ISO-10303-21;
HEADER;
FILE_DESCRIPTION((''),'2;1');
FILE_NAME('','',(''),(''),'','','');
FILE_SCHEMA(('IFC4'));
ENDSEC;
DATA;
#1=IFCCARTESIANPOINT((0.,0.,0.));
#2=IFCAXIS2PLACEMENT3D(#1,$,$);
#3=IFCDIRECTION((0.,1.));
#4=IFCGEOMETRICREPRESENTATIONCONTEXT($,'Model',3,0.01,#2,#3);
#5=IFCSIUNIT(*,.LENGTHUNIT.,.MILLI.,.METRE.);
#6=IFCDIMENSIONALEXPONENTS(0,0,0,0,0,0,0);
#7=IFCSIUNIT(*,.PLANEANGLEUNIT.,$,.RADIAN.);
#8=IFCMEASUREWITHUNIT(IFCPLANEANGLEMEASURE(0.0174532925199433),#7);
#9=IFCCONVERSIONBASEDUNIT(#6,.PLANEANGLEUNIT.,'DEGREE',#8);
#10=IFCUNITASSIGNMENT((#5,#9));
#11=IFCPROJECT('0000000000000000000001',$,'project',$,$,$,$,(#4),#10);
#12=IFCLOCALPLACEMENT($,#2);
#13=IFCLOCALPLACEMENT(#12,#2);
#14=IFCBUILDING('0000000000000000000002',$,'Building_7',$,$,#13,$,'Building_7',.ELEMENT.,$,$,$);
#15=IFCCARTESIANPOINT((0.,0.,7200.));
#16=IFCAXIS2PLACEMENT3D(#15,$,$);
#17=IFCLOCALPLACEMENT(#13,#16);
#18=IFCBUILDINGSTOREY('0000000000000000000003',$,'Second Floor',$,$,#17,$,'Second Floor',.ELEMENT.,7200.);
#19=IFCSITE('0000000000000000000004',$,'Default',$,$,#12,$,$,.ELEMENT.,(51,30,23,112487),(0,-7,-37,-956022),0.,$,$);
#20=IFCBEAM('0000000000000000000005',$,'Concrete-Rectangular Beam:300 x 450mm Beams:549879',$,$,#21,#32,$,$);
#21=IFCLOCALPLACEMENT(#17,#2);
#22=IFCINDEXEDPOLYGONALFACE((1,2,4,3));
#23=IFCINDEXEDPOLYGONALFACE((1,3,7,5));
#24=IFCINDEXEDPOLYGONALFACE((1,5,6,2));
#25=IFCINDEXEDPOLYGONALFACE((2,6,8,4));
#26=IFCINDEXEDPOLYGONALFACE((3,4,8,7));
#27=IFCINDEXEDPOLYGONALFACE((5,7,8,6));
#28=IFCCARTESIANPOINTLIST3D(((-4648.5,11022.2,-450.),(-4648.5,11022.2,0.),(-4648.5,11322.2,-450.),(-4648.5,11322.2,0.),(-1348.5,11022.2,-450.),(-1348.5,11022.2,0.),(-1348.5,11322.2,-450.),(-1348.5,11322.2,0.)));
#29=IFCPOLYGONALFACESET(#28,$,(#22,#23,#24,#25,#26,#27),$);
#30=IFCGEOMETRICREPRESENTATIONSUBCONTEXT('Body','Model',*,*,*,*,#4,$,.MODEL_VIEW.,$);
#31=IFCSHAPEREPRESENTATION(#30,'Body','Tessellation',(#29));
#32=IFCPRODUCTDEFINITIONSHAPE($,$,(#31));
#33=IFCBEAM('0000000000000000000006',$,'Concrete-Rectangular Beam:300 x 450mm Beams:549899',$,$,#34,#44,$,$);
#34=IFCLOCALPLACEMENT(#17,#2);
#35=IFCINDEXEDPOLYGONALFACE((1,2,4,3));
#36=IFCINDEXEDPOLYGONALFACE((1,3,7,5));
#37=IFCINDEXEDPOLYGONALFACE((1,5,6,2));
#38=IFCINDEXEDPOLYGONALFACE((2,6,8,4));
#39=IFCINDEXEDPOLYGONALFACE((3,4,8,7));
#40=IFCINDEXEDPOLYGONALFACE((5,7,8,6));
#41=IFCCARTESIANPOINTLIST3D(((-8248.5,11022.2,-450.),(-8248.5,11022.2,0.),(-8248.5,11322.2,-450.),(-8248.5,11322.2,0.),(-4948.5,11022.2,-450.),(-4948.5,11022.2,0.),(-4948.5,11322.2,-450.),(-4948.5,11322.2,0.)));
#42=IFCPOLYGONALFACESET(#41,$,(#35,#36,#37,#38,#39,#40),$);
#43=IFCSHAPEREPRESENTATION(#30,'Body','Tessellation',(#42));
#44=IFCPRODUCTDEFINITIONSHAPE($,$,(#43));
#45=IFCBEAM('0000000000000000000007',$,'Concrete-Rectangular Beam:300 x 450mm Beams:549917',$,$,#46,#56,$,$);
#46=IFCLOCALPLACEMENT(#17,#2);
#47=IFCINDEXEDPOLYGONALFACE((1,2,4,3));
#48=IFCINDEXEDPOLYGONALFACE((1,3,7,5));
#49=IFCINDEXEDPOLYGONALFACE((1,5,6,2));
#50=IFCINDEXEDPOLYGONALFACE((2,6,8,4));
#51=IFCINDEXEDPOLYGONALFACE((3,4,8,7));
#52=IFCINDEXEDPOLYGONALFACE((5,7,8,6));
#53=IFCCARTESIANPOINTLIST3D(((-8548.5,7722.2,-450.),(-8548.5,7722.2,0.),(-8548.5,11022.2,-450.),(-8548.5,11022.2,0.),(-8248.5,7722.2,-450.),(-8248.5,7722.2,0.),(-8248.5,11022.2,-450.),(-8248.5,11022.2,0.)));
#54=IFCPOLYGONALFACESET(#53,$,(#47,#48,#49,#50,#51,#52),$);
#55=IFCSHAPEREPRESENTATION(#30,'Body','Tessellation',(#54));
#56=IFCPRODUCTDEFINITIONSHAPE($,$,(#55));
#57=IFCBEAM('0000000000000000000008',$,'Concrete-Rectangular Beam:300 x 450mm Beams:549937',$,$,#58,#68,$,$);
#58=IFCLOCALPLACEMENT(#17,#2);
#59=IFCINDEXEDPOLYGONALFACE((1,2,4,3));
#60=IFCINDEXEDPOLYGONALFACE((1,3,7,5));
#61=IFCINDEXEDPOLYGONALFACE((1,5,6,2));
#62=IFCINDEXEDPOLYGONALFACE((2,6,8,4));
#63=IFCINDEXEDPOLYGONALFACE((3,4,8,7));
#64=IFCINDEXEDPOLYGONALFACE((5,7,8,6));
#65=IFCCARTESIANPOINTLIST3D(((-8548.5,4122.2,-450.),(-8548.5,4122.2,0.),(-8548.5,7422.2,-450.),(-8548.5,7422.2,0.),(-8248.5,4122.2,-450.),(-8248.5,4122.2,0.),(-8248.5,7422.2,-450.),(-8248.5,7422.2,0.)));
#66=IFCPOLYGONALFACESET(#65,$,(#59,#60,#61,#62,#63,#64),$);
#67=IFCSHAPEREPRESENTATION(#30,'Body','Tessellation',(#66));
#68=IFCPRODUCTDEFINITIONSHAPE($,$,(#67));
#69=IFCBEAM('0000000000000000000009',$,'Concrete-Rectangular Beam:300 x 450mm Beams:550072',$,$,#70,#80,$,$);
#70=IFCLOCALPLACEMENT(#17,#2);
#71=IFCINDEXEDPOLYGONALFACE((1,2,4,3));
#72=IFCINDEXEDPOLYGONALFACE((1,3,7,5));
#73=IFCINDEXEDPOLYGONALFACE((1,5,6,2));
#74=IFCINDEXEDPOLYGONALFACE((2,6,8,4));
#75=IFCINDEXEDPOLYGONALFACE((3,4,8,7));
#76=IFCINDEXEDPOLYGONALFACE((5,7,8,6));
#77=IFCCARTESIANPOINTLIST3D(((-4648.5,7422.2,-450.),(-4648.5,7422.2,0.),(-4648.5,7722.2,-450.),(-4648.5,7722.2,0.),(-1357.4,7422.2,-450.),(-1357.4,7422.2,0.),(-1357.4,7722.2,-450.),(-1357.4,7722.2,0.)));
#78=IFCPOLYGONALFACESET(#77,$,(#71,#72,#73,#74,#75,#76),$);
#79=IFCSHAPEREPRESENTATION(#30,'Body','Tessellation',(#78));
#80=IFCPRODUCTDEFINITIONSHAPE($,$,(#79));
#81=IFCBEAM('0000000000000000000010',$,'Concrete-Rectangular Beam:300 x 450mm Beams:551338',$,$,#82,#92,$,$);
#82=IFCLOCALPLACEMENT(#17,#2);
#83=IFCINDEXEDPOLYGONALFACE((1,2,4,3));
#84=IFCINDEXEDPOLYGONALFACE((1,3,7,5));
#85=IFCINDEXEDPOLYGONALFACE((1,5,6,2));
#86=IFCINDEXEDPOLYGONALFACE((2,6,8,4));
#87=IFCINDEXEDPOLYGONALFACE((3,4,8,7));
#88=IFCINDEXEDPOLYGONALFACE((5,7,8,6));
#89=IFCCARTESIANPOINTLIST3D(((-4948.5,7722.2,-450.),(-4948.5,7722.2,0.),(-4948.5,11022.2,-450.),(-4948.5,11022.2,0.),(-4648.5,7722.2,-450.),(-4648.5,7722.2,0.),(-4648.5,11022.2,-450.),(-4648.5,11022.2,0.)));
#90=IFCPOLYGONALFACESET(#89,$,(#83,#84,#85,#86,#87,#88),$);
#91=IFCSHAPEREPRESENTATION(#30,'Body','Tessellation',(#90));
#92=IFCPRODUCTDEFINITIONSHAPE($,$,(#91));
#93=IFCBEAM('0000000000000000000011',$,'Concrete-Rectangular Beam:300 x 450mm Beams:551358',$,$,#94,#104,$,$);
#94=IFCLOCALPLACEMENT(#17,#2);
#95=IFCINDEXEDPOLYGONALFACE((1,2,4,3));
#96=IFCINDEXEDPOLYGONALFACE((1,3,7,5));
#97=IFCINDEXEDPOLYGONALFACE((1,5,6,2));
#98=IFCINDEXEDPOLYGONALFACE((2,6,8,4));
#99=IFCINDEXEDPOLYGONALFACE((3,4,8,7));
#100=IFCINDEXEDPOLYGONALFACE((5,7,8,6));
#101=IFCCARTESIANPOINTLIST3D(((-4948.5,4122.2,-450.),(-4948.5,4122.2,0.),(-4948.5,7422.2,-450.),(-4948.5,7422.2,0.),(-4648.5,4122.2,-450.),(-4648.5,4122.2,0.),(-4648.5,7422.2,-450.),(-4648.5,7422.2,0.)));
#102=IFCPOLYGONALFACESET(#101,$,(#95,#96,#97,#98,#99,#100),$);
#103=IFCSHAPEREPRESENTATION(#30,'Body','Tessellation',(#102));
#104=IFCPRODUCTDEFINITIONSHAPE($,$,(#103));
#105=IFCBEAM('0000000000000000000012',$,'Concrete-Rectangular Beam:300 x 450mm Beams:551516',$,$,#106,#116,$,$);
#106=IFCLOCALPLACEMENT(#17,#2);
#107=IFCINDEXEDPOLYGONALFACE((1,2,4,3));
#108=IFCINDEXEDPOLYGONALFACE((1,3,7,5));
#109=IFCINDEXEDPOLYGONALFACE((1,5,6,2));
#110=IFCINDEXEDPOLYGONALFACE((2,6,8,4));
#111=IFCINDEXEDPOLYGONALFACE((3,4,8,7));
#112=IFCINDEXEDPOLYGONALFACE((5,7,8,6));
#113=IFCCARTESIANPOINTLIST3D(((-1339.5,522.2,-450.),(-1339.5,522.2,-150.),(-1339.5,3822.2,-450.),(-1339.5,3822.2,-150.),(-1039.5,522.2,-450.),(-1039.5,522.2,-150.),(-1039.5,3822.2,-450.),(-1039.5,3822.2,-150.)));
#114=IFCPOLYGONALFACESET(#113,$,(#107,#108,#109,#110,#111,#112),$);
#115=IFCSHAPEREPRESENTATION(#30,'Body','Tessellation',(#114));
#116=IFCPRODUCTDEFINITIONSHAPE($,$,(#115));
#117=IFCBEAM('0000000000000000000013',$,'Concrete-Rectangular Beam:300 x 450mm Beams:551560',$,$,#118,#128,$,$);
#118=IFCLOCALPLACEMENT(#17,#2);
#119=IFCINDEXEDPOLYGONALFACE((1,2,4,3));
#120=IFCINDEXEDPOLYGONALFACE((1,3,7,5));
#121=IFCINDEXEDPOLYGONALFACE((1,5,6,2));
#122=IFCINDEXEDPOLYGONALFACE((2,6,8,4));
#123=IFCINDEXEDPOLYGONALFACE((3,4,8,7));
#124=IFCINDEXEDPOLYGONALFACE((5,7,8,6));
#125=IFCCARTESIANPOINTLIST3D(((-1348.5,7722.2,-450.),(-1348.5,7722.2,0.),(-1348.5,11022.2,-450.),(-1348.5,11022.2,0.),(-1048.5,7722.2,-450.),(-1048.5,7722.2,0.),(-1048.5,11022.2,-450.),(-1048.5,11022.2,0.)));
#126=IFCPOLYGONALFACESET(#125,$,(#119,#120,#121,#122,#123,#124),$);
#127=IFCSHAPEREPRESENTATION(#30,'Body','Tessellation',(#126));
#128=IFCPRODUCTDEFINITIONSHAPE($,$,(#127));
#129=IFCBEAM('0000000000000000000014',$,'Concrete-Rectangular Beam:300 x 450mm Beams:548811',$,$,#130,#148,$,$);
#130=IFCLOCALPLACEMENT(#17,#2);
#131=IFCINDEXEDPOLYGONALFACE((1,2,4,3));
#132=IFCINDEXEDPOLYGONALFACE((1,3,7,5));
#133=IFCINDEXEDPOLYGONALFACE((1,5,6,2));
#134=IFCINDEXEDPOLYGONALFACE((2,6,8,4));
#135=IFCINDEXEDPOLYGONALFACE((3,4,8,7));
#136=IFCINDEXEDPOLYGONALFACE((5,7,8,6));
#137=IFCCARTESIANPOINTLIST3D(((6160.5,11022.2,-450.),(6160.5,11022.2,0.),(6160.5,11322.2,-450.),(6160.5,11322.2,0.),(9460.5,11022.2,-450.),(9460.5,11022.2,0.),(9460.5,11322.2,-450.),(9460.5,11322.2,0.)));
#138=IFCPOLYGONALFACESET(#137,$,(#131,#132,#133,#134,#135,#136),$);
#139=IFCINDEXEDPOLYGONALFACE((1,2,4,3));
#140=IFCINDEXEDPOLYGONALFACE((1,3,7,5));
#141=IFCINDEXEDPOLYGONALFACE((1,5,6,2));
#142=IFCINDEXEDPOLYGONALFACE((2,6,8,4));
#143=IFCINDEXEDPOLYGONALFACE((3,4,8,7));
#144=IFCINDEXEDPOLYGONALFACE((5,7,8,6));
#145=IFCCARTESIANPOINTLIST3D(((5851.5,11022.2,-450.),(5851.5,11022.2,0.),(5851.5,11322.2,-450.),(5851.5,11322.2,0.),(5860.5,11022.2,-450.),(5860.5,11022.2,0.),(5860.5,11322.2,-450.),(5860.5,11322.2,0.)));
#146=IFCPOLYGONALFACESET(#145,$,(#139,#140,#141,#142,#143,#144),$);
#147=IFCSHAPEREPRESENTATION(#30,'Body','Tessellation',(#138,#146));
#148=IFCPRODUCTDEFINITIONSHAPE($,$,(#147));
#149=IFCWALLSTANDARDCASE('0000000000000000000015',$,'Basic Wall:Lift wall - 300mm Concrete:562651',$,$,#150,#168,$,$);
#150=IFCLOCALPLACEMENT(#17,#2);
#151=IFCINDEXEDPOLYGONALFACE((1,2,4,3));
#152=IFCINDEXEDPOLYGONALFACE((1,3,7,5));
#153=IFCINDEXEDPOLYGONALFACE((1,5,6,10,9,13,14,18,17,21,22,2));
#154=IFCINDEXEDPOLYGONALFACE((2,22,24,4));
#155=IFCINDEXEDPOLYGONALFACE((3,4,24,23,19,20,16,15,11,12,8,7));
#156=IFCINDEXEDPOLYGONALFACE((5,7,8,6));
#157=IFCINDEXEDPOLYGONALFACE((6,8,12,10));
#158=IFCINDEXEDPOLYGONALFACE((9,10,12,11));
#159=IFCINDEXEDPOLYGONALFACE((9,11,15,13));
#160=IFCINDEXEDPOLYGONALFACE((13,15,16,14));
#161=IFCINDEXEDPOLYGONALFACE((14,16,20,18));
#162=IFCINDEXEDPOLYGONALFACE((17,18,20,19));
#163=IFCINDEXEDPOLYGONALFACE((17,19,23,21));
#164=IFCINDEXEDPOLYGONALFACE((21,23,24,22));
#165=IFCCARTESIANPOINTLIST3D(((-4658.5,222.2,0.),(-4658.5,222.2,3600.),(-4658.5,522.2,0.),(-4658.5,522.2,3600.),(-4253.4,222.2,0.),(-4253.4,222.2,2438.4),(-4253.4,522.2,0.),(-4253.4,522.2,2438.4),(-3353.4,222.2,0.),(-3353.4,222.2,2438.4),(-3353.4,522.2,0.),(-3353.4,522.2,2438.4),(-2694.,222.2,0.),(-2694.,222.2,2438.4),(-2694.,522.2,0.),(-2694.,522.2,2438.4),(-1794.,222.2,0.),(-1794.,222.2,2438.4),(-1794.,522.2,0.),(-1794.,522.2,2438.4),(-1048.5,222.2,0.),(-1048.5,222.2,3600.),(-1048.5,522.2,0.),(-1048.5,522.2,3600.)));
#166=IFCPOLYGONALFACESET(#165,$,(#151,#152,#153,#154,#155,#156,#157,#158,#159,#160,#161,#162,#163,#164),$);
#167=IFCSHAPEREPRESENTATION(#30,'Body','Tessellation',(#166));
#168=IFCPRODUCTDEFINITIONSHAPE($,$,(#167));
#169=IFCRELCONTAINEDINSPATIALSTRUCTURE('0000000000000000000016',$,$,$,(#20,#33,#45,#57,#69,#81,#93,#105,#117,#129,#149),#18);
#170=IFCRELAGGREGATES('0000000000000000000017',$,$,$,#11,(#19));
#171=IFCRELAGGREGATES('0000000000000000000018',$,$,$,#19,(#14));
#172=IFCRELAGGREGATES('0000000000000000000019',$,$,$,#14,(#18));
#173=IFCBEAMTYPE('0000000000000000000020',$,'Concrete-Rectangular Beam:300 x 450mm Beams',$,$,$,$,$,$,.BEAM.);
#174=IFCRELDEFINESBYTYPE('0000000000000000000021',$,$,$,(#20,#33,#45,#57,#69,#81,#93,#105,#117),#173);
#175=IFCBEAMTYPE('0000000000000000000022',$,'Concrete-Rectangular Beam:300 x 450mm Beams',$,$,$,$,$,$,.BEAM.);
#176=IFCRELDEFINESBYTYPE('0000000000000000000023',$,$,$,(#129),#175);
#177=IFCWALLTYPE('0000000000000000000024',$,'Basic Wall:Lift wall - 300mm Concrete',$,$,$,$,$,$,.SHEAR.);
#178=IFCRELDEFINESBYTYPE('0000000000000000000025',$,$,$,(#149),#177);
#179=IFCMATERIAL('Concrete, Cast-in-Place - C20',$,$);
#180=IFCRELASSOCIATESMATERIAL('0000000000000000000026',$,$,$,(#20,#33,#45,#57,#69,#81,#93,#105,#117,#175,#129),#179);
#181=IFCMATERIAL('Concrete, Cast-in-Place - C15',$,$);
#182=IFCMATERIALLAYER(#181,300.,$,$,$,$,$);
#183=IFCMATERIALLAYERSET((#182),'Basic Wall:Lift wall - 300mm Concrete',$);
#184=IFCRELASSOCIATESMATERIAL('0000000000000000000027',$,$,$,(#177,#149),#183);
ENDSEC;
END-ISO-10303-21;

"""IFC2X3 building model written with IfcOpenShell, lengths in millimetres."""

from ifc_helpers import new_model, entity, si_unit, converted_unit, direction, frame, frame_2d, origin, origin_2d_with_axis, place, context, subcontext, project, spatial, rectangle, extrude, source, transform, mapped, material, layer, layer_set, layer_usage, type_object, type_shapes, element, save


model = new_model("IFC2X3")

# Units and contexts
model_context = context("Model", 3, precision=0.01, world=origin(), true_north=direction((0.0, 1.0)))
body_context = subcontext(model_context, "Body", "Model", "MODEL_VIEW")
ifc_project = project(units=[si_unit("LENGTHUNIT", "METRE", prefix="MILLI"), converted_unit("PLANEANGLEUNIT", "DEGREE", entity("IfcPlaneAngleMeasure", 0.0174532925199433), si_unit("PLANEANGLEUNIT", "RADIAN"), dimensions=[0, 0, 0, 0, 0, 0, 0])], contexts=[model_context])

# Site, building, storey
site_placement = place(None, origin())
site = spatial("IfcSite", under=ifc_project, at=site_placement, Name="Default", CompositionType="ELEMENT", RefLatitude=(51, 30, 23, 112487), RefLongitude=(0, -7, -37, -956022), RefElevation=0.0)
building_placement = place(site_placement, origin())
building = spatial("IfcBuilding", under=site, at=building_placement, Name="Building_7", LongName="Building_7", CompositionType="ELEMENT")
storey_placement = place(building_placement, frame((0.0, 0.0, 7200.0)))
storey = spatial("IfcBuildingStorey", under=building, at=storey_placement, Name="Second Floor", LongName="Second Floor", CompositionType="ELEMENT", Elevation=7200.0)

# Beams
ifc_material_1 = material(Name="Concrete, Cast-in-Place - C20")
beam_type_1 = type_object("IfcBeamType", Name="Concrete-Rectangular Beam:300 x 450mm Beams", PredefinedType="BEAM")
beam_1_placement = place(storey_placement, frame((-1198.5, 11172.2, 0.0), z_axis=(0.0, 0.0, 1.0), x_axis=(-1.0, 0.0, 0.0)))
element("IfcBeam", 1, at=beam_1_placement, inside=storey, type_object=beam_type_1, material=ifc_material_1, Name="Concrete-Rectangular Beam:300 x 450mm Beams:549879", context=body_context, shape_type="SweptSolid", body=[
    extrude(rectangle(XDim=450.0, YDim=300.0, at=frame_2d((0.0, 0.0), x_axis=(1.0, 0.0))), frame((150.0, 0.0, -225.0), z_axis=(1.0, 0.0, 0.0), x_axis=(0.0, 0.0, -1.0)), (0.0, 0.0, 1.0), 3300.0),
])
beam_2_placement = place(storey_placement, frame((-4798.5, 11172.2, 0.0), z_axis=(0.0, 0.0, 1.0), x_axis=(-1.0, 0.0, 0.0)))
element("IfcBeam", 2, at=beam_2_placement, inside=storey, type_object=beam_type_1, material=ifc_material_1, Name="Concrete-Rectangular Beam:300 x 450mm Beams:549899", context=body_context, shape_type="SweptSolid", body=[
    extrude(rectangle(XDim=450.0, YDim=300.0, at=frame_2d((0.0, 0.0), x_axis=(1.0, 0.0))), frame((150.0, 0.0, -225.0), z_axis=(1.0, 0.0, 0.0), x_axis=(0.0, 0.0, -1.0)), (0.0, 0.0, 1.0), 3300.0),
])
beam_3_placement = place(storey_placement, frame((-8398.5, 11172.2, 0.0), z_axis=(0.0, 0.0, 1.0), x_axis=(0.0, -1.0, 0.0)))
element("IfcBeam", 3, at=beam_3_placement, inside=storey, type_object=beam_type_1, material=ifc_material_1, Name="Concrete-Rectangular Beam:300 x 450mm Beams:549917", context=body_context, shape_type="SweptSolid", body=[
    extrude(rectangle(XDim=450.0, YDim=300.0, at=frame_2d((0.0, 0.0), x_axis=(1.0, 0.0))), frame((150.0, 0.0, -225.0), z_axis=(1.0, 0.0, 0.0), x_axis=(0.0, 0.0, -1.0)), (0.0, 0.0, 1.0), 3300.0),
])
beam_4_placement = place(storey_placement, frame((-8398.5, 7572.2, 0.0), z_axis=(0.0, 0.0, 1.0), x_axis=(0.0, -1.0, 0.0)))
element("IfcBeam", 4, at=beam_4_placement, inside=storey, type_object=beam_type_1, material=ifc_material_1, Name="Concrete-Rectangular Beam:300 x 450mm Beams:549937", context=body_context, shape_type="SweptSolid", body=[
    extrude(rectangle(XDim=450.0, YDim=300.0, at=frame_2d((0.0, 0.0), x_axis=(1.0, 0.0))), frame((150.0, 0.0, -225.0), z_axis=(1.0, 0.0, 0.0), x_axis=(0.0, 0.0, -1.0)), (0.0, 0.0, 1.0), 3300.0),
])
beam_5_placement = place(storey_placement, frame((-1207.4, 7572.2, 0.0), z_axis=(0.0, 0.0, 1.0), x_axis=(-1.0, 0.0, 0.0)))
element("IfcBeam", 5, at=beam_5_placement, inside=storey, type_object=beam_type_1, material=ifc_material_1, Name="Concrete-Rectangular Beam:300 x 450mm Beams:550072", context=body_context, shape_type="SweptSolid", body=[
    extrude(rectangle(XDim=450.0, YDim=300.0, at=origin_2d_with_axis()), frame((150.0, 0.0, -225.0), z_axis=(1.0, 0.0, 0.0), x_axis=(0.0, 0.0, -1.0)), (0.0, 0.0, 1.0), 3291.1),
])
for number, where, z_axis, x_axis, name in (
    (6, (-4798.5, 11172.2, 0.0), (0.0, 0.0, 1.0), (0.0, -1.0, 0.0), "Concrete-Rectangular Beam:300 x 450mm Beams:551338"),
    (7, (-4798.5, 7572.2, 0.0), (0.0, 0.0, 1.0), (0.0, -1.0, 0.0), "Concrete-Rectangular Beam:300 x 450mm Beams:551358"),
):
    element("IfcBeam", number, at=place(storey_placement, frame(where, z_axis=z_axis, x_axis=x_axis)), inside=storey, type_object=beam_type_1, material=ifc_material_1, Name=name, context=body_context, shape_type="SweptSolid", body=[
        extrude(rectangle(XDim=450.0, YDim=300.0, at=origin_2d_with_axis()), frame((150.0, 0.0, -225.0), z_axis=(1.0, 0.0, 0.0), x_axis=(0.0, 0.0, -1.0)), (0.0, 0.0, 1.0), 3300.0),
    ])
beam_6_placement = place(storey_placement, frame((-1189.5, 372.2, 0.0), z_axis=(0.0, 0.0, 1.0), x_axis=(0.0, 1.0, 0.0)))
element("IfcBeam", 8, at=beam_6_placement, inside=storey, type_object=beam_type_1, material=ifc_material_1, Name="Concrete-Rectangular Beam:300 x 450mm Beams:551516", context=body_context, shape_type="SweptSolid", body=[
    extrude(rectangle(XDim=300.0, YDim=300.0, at=frame_2d((0.0, 0.0), x_axis=(1.0, 0.0))), frame((150.0, 0.0, -300.0), z_axis=(1.0, 0.0, 0.0), x_axis=(0.0, 0.0, -1.0)), (0.0, 0.0, 1.0), 3300.0),
])
beam_7_placement = place(storey_placement, frame((-1198.5, 11172.2, 0.0), z_axis=(0.0, 0.0, 1.0), x_axis=(0.0, -1.0, 0.0)))
element("IfcBeam", 9, at=beam_7_placement, inside=storey, type_object=beam_type_1, material=ifc_material_1, Name="Concrete-Rectangular Beam:300 x 450mm Beams:551560", context=body_context, shape_type="SweptSolid", body=[
    extrude(rectangle(XDim=450.0, YDim=300.0, at=origin_2d_with_axis()), frame((150.0, 0.0, -225.0), z_axis=(1.0, 0.0, 0.0), x_axis=(0.0, 0.0, -1.0)), (0.0, 0.0, 1.0), 3300.0),
])

# Beam
beam_type_2 = type_object("IfcBeamType", Name="Concrete-Rectangular Beam:300 x 450mm Beams", PredefinedType="BEAM", material=ifc_material_1)
shared_shape_1 = source(origin(), body_context, "Body", "SweptSolid", [
    extrude(rectangle(XDim=450.0, YDim=300.0, at=frame_2d((0.0, 0.0), x_axis=(1.0, 0.0))), frame((6160.5, 11172.2, 6975.0), z_axis=(1.0, 0.0, 0.0), x_axis=(0.0, 0.0, -1.0)), (0.0, 0.0, 1.0), 3300.0),
    extrude(rectangle(XDim=450.0, YDim=300.0, at=frame_2d((0.0, 0.0), x_axis=(1.0, 0.0))), frame((5851.5, 11172.2, 6975.0), z_axis=(1.0, 0.0, 0.0), x_axis=(0.0, 0.0, -1.0)), (0.0, 0.0, 1.0), 8.9),
])
type_shapes(beam_type_2, [shared_shape_1])
beam_8_placement = place(storey_placement, frame((0.0, 0.0, -7200.0)))
element("IfcBeam", 10, at=beam_8_placement, inside=storey, type_object=beam_type_2, material=ifc_material_1, Name="Concrete-Rectangular Beam:300 x 450mm Beams:548811", context=body_context, shape_type="MappedRepresentation", body=[
    mapped(shared_shape_1, transform((0.0, 0.0, 0.0), scale=1.0)),
])

# Wall, openings
ifc_material_2 = material(Name="Concrete, Cast-in-Place - C15")
ifc_layer_1 = layer(ifc_material_2, 300.0)
ifc_layer_set_1 = layer_set([ifc_layer_1], Name="Basic Wall:Lift wall - 300mm Concrete")
ifc_layer_usage_1 = layer_usage(ifc_layer_set_1, "AXIS2", "NEGATIVE", 150.0)
wall_type_1 = type_object("IfcWallType", Name="Basic Wall:Lift wall - 300mm Concrete", PredefinedType="SHEAR", material=ifc_layer_set_1)
wall_1_placement = place(storey_placement, frame((-1048.5, 372.2, 0.0), z_axis=(0.0, 0.0, 1.0), x_axis=(-1.0, 0.0, 0.0)))
wall_1 = element("IfcWallStandardCase", 11, at=wall_1_placement, inside=storey, type_object=wall_type_1, material=ifc_layer_usage_1, Name="Basic Wall:Lift wall - 300mm Concrete:562651", context=body_context, shape_type="SweptSolid", body=[
    extrude(rectangle(XDim=3610.0, YDim=300.0, at=frame_2d((1805.0, 0.0), x_axis=(1.0, 0.0))), origin(), (0.0, 0.0, 1.0), 3600.0),
])
opening_1_placement = place(wall_1_placement, origin())
element("IfcOpeningElement", 12, at=opening_1_placement, cuts=wall_1, ObjectType="Opening", context=body_context, shape_type="SweptSolid", body=[
    extrude(rectangle(XDim=2438.4, YDim=900.0, at=frame_2d((0.0, 0.0), x_axis=(1.0, 0.0))), frame((1195.6, -150.0, 1219.2), z_axis=(0.0, 1.0, 0.0), x_axis=(0.0, 0.0, -1.0)), (0.0, 0.0, 1.0), 300.0),
])
opening_2_placement = place(wall_1_placement, origin())
element("IfcOpeningElement", 13, at=opening_2_placement, cuts=wall_1, ObjectType="Opening", context=body_context, shape_type="SweptSolid", body=[
    extrude(rectangle(XDim=2438.4, YDim=900.0, at=frame_2d((0.0, 0.0), x_axis=(1.0, 0.0))), frame((2755.0, -150.0, 1219.2), z_axis=(0.0, 1.0, 0.0), x_axis=(0.0, 0.0, -1.0)), (0.0, 0.0, 1.0), 300.0),
])

save(model, "model.ifc")
